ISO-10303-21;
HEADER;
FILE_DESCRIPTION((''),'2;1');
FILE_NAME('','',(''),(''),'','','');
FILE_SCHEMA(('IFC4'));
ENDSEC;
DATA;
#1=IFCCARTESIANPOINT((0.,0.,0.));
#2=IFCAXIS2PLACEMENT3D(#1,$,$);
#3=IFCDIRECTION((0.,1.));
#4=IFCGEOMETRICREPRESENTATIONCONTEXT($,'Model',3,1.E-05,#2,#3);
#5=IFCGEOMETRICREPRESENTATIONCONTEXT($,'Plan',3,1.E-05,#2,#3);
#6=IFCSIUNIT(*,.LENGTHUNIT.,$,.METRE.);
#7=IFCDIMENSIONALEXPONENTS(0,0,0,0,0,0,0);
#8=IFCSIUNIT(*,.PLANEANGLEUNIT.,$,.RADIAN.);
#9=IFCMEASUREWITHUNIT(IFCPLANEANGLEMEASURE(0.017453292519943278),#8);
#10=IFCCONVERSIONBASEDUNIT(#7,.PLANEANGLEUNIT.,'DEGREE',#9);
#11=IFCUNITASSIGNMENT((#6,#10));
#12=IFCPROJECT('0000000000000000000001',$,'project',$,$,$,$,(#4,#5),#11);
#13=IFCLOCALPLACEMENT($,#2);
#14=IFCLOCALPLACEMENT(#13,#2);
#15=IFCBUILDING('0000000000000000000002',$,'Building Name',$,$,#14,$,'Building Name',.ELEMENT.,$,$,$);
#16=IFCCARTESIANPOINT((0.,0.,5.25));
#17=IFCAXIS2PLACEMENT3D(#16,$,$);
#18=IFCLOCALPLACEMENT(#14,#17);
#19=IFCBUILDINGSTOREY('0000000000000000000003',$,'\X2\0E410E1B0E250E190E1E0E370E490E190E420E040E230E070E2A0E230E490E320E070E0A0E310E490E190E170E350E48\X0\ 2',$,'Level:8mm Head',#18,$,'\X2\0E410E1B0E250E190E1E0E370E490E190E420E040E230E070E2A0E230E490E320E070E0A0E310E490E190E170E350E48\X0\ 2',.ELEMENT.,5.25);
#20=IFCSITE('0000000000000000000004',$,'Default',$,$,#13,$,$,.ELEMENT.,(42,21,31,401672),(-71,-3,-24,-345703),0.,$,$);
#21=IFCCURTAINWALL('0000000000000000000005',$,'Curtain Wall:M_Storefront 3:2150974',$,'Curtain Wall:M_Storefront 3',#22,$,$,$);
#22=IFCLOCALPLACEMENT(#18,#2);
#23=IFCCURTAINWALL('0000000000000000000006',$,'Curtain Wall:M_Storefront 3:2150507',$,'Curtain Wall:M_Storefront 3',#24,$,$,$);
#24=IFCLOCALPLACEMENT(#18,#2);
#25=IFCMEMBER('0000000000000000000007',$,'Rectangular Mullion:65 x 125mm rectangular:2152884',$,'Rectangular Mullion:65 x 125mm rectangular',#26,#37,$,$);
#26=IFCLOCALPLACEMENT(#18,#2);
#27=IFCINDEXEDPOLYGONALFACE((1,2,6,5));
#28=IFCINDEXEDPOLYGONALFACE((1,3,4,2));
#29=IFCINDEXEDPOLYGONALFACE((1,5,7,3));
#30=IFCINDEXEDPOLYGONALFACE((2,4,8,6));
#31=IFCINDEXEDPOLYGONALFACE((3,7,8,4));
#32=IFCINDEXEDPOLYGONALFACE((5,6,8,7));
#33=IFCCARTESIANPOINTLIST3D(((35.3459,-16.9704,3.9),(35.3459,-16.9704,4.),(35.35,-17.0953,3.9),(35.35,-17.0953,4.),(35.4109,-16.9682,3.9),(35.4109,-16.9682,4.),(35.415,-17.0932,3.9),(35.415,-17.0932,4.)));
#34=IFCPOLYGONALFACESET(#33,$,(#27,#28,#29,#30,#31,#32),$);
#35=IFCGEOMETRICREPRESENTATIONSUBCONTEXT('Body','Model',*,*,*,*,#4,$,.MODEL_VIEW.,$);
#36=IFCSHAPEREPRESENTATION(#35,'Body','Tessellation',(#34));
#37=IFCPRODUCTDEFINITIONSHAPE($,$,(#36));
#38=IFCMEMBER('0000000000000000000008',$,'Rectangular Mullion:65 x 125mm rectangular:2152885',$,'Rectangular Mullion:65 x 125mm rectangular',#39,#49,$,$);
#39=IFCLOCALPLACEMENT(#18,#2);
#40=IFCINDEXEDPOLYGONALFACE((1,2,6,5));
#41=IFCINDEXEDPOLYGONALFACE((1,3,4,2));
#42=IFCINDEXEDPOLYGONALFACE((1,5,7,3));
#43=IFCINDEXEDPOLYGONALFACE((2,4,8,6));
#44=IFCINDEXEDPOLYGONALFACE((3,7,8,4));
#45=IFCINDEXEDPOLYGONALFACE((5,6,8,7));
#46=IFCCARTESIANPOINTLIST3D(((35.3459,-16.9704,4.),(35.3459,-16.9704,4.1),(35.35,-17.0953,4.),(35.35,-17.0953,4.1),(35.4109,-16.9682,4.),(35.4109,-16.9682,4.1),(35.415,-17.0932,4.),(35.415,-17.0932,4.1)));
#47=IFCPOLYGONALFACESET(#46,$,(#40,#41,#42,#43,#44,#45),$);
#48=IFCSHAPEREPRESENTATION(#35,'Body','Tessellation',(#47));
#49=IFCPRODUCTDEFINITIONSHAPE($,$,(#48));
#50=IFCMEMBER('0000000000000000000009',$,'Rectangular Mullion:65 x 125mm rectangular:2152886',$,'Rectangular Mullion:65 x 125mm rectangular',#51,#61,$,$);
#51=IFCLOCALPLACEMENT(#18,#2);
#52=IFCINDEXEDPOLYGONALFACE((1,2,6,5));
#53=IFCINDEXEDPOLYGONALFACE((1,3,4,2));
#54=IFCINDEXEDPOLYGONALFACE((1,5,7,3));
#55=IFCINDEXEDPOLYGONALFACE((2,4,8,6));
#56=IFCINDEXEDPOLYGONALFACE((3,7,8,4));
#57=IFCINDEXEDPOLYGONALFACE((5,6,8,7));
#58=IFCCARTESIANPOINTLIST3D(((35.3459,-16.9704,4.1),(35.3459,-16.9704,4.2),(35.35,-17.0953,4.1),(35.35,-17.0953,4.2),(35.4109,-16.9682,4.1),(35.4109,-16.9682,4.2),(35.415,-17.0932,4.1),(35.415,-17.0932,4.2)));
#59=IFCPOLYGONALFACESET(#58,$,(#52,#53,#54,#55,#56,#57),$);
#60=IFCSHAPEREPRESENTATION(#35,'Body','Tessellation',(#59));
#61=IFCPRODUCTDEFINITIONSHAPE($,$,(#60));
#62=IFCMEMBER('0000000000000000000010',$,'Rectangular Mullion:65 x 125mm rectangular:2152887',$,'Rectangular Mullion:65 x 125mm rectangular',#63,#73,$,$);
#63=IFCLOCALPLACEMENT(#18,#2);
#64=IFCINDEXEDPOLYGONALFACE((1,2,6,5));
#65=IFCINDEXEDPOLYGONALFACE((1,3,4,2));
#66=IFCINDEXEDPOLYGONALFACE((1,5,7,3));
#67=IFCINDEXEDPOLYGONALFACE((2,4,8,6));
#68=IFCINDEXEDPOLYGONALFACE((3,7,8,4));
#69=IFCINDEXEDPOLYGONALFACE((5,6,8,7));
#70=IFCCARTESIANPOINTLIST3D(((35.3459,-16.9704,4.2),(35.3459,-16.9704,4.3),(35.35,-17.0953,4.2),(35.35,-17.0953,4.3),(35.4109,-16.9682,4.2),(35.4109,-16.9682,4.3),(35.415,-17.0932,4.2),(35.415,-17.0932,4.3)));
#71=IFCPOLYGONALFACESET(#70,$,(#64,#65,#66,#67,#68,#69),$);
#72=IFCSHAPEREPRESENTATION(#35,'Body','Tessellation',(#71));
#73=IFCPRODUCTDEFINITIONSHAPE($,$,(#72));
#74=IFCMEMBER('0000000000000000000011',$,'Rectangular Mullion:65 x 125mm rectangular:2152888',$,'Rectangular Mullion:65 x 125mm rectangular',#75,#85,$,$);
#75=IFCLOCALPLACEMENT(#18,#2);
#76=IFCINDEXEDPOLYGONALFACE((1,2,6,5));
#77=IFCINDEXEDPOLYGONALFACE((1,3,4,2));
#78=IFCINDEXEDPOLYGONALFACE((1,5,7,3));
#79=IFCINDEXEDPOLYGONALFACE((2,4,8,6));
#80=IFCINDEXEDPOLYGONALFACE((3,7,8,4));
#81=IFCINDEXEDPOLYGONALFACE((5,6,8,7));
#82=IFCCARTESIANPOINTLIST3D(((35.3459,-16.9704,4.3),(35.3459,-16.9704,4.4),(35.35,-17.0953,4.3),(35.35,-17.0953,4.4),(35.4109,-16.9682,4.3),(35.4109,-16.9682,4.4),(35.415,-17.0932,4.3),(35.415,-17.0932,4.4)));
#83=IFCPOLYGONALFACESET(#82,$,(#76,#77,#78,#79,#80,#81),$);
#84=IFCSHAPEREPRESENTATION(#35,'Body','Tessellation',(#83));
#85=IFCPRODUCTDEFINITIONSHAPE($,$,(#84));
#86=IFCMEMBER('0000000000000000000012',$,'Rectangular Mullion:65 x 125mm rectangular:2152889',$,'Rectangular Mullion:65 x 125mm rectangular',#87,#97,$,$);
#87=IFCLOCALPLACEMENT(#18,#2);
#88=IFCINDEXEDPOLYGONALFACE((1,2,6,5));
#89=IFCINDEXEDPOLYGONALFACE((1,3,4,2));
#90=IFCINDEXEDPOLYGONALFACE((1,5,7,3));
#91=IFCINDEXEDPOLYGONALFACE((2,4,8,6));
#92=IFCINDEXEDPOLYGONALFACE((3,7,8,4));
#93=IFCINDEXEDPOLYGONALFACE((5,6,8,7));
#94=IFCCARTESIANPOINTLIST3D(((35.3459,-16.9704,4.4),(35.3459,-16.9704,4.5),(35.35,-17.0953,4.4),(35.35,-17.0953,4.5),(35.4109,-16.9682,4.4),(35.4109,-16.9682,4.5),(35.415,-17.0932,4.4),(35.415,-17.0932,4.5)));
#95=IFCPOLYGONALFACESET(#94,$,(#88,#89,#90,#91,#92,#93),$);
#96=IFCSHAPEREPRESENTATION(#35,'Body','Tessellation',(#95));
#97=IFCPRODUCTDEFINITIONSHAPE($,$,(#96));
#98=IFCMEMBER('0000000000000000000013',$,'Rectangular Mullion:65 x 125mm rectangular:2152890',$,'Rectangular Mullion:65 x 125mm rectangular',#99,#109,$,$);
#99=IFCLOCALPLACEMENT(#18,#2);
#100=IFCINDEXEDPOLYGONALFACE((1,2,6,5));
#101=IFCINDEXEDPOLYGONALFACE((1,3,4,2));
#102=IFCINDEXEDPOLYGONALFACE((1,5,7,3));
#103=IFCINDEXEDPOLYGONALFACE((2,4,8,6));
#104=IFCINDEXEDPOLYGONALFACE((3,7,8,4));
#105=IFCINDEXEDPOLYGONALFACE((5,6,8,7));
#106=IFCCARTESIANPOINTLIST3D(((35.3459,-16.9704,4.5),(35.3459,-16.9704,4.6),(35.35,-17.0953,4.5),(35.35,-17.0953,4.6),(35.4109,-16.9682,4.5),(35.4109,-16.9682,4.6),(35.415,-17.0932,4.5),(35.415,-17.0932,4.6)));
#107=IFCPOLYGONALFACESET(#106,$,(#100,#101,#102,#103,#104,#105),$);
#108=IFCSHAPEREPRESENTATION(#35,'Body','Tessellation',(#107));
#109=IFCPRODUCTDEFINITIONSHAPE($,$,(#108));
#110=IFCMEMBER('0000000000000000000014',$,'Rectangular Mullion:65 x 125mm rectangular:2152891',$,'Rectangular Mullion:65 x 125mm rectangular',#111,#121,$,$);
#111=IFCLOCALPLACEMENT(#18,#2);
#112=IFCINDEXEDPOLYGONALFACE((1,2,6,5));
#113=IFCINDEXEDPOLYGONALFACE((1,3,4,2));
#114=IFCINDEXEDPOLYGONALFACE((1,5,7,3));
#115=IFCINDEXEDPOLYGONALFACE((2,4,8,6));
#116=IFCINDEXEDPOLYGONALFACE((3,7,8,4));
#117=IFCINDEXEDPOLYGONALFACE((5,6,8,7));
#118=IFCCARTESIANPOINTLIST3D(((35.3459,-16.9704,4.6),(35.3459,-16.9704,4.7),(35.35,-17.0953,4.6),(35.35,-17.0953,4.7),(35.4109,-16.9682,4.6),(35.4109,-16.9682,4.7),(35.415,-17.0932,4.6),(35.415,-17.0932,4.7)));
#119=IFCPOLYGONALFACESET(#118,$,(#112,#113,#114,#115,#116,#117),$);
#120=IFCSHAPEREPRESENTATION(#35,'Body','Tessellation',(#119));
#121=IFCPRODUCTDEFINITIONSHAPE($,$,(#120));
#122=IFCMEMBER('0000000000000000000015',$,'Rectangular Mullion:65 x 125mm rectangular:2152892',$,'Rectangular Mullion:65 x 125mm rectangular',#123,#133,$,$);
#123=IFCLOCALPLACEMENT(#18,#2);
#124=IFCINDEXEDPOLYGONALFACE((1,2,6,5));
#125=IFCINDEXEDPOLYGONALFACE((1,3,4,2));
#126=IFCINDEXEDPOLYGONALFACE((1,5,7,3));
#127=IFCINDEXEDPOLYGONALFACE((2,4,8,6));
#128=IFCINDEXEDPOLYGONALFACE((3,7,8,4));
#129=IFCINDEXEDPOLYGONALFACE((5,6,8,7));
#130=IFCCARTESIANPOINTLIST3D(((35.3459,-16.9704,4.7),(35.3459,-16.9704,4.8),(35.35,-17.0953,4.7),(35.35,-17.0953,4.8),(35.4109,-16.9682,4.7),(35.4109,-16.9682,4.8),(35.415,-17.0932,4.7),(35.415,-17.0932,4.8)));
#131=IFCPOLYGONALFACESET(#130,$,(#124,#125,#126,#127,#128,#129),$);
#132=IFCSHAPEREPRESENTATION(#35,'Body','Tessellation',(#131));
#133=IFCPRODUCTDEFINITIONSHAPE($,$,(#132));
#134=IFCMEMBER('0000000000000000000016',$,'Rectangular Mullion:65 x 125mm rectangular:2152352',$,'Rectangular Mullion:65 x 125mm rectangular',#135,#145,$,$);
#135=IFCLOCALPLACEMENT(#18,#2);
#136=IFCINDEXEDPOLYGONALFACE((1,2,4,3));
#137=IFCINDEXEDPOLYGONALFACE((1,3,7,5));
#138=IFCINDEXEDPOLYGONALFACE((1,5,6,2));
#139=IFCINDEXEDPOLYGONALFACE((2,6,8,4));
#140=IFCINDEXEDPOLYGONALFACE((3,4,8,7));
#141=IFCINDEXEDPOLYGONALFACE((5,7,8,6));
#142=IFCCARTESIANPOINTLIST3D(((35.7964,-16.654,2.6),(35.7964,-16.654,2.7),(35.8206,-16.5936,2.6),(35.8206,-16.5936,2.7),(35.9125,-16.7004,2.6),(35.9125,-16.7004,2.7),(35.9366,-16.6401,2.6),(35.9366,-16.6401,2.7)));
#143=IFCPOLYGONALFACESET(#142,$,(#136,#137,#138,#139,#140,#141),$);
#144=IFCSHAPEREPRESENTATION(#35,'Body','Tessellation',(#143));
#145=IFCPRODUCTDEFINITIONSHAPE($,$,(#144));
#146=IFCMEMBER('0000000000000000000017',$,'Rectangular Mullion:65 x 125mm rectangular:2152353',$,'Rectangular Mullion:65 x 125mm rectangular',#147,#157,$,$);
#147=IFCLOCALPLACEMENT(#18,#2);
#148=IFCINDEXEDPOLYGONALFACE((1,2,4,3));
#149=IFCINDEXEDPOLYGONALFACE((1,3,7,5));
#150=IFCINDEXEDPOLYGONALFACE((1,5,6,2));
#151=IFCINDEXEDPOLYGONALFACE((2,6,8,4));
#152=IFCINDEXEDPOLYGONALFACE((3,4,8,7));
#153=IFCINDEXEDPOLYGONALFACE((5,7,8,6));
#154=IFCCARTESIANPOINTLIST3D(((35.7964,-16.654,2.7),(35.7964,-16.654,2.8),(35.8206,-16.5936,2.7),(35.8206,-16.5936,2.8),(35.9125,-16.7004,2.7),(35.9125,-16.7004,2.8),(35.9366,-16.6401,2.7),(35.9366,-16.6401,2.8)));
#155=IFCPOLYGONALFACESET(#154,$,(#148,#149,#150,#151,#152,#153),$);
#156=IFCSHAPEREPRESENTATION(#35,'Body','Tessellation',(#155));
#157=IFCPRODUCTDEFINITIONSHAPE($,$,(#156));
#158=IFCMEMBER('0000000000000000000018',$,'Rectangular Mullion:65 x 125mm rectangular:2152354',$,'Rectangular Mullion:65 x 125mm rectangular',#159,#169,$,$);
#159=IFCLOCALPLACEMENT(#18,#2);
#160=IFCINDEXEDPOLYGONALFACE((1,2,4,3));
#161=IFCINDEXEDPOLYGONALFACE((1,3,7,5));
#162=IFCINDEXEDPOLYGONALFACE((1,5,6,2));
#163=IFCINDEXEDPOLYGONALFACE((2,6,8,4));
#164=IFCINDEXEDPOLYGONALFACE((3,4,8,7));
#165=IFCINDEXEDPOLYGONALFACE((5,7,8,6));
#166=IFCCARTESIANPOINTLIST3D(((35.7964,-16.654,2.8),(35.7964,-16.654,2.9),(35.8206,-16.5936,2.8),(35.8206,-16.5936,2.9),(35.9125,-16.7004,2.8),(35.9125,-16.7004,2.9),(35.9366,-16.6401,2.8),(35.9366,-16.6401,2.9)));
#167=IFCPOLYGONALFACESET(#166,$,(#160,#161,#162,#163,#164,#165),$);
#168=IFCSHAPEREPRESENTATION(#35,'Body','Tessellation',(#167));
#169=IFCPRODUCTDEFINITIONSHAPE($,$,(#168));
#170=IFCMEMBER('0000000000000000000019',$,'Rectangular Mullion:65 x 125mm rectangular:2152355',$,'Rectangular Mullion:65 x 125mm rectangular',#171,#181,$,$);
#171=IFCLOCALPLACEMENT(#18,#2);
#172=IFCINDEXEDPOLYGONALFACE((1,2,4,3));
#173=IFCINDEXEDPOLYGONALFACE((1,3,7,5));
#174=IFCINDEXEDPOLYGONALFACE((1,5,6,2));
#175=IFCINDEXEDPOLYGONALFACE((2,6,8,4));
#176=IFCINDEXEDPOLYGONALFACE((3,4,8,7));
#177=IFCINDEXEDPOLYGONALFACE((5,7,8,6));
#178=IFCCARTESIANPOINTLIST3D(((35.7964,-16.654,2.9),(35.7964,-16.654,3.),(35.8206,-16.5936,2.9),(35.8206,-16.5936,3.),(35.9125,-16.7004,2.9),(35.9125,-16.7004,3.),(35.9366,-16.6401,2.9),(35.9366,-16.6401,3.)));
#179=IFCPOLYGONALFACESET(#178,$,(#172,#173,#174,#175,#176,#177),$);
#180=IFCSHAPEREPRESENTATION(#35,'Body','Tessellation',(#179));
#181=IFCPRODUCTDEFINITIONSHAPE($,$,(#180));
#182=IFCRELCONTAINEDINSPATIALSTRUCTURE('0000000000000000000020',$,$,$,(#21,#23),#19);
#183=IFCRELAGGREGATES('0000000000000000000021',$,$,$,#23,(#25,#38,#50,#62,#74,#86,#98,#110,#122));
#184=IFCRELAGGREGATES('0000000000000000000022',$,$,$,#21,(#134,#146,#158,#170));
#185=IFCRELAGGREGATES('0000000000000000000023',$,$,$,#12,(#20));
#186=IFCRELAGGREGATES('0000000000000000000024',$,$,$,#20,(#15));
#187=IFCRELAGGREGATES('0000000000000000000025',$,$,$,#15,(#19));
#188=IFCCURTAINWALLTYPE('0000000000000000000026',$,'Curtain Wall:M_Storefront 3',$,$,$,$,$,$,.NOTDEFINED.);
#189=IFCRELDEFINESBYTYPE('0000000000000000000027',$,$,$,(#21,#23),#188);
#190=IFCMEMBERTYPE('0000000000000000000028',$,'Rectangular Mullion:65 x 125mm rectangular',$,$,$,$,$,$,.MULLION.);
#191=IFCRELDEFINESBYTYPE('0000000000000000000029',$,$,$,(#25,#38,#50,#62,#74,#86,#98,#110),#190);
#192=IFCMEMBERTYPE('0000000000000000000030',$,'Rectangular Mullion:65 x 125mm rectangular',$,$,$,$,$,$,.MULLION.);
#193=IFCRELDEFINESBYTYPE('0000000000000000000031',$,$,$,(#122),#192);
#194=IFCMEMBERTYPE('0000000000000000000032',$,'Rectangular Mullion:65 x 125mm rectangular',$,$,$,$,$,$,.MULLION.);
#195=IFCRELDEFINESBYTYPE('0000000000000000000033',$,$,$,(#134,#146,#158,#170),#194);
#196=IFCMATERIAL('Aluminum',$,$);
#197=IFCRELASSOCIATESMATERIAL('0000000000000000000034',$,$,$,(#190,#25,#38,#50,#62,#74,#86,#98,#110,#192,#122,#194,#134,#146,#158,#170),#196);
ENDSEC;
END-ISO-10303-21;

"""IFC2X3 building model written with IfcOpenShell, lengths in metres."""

from ifc_helpers import new_model, entity, si_unit, converted_unit, direction, frame, origin, origin_2d_with_axis, place, context, subcontext, project, spatial, rectangle, extrude, source, transform, mapped, material, type_object, type_shapes, element, aggregate, save


model = new_model("IFC2X3")

# Units and contexts
model_context = context("Model", 3, precision=1e-05, world=origin(), true_north=direction((0.0, 1.0)))
plan_context = context("Plan", 3, precision=1e-05, world=origin(), true_north=direction((0.0, 1.0)))
body_context = subcontext(model_context, "Body", "Model", "MODEL_VIEW")
ifc_project = project(units=[si_unit("LENGTHUNIT", "METRE"), converted_unit("PLANEANGLEUNIT", "DEGREE", entity("IfcPlaneAngleMeasure", 0.017453292519943278), si_unit("PLANEANGLEUNIT", "RADIAN"), dimensions=[0, 0, 0, 0, 0, 0, 0])], contexts=[model_context, plan_context])

# Site, building, storey
site_placement = place(None, origin())
site = spatial("IfcSite", under=ifc_project, at=site_placement, Name="Default", CompositionType="ELEMENT", RefLatitude=(42, 21, 31, 401672), RefLongitude=(-71, -3, -24, -345703), RefElevation=0.0)
building_placement = place(site_placement, origin())
building = spatial("IfcBuilding", under=site, at=building_placement, Name="Building Name", LongName="Building Name", CompositionType="ELEMENT")
storey_placement = place(building_placement, frame((0.0, 0.0, 5.25)))
storey = spatial("IfcBuildingStorey", under=building, at=storey_placement, Name="แปลนพื้นโครงสร้างชั้นที่ 2", ObjectType="Level:8mm Head", LongName="แปลนพื้นโครงสร้างชั้นที่ 2", CompositionType="ELEMENT", Elevation=5.25)

# Curtain wall
curtain_wall_type = type_object("IfcCurtainWallType", Name="Curtain Wall:M_Storefront 3", PredefinedType="NOTDEFINED")
curtain_wall_1_placement = place(storey_placement, frame((0.0, 0.0, -5.25)))
curtain_wall_1 = element("IfcCurtainWall", 1, at=curtain_wall_1_placement, inside=storey, type_object=curtain_wall_type, Name="Curtain Wall:M_Storefront 3:2150974", ObjectType="Curtain Wall:M_Storefront 3")
ifc_material = material(Name="Aluminum")

# Curtain wall, members
curtain_wall_2_placement = place(storey_placement, frame((0.0, 0.0, -5.25)))
curtain_wall_2 = element("IfcCurtainWall", 2, at=curtain_wall_2_placement, inside=storey, type_object=curtain_wall_type, Name="Curtain Wall:M_Storefront 3:2150507", ObjectType="Curtain Wall:M_Storefront 3")
member_type_1 = type_object("IfcMemberType", Name="Rectangular Mullion:65 x 125mm rectangular", PredefinedType="MULLION", material=ifc_material)
shared_shape_1 = source(origin(), body_context, "Body", "SweptSolid", [
    extrude(rectangle(XDim=0.065, YDim=0.125, at=origin_2d_with_axis()), frame((-0.0325, 0.0, -0.1), z_axis=(0.0, 0.0, 1.0), x_axis=(-1.0, 0.0, 0.0)), (0.0, 0.0, 1.0), 0.1),
])
type_shapes(member_type_1, [shared_shape_1])
member_1_placement = place(curtain_wall_2_placement, frame((35.4129, -17.0307, 9.15), z_axis=(0.0, 0.0, -1.0), x_axis=(0.99946, 0.032862, 0.0)))
member_1 = element("IfcMember", 3, at=member_1_placement, type_object=member_type_1, material=ifc_material, Name="Rectangular Mullion:65 x 125mm rectangular:2152884", ObjectType="Rectangular Mullion:65 x 125mm rectangular", context=body_context, shape_type="MappedRepresentation", body=[
    mapped(shared_shape_1, transform((0.0, 0.0, 0.0), scale=1.0)),
])
member_2_placement = place(curtain_wall_2_placement, frame((35.4129, -17.0307, 9.25), z_axis=(0.0, 0.0, -1.0), x_axis=(0.99946, 0.032862, 0.0)))
member_2 = element("IfcMember", 4, at=member_2_placement, type_object=member_type_1, material=ifc_material, Name="Rectangular Mullion:65 x 125mm rectangular:2152885", ObjectType="Rectangular Mullion:65 x 125mm rectangular", context=body_context, shape_type="MappedRepresentation", body=[
    mapped(shared_shape_1, transform((0.0, 0.0, 0.0), scale=1.0)),
])
member_3_placement = place(curtain_wall_2_placement, frame((35.4129, -17.0307, 9.35), z_axis=(0.0, 0.0, -1.0), x_axis=(0.99946, 0.032862, 0.0)))
member_3 = element("IfcMember", 5, at=member_3_placement, type_object=member_type_1, material=ifc_material, Name="Rectangular Mullion:65 x 125mm rectangular:2152886", ObjectType="Rectangular Mullion:65 x 125mm rectangular", context=body_context, shape_type="MappedRepresentation", body=[
    mapped(shared_shape_1, transform((0.0, 0.0, 0.0), scale=1.0)),
])
member_4_placement = place(curtain_wall_2_placement, frame((35.4129, -17.0307, 9.45), z_axis=(0.0, 0.0, -1.0), x_axis=(0.99946, 0.032862, 0.0)))
member_4 = element("IfcMember", 6, at=member_4_placement, type_object=member_type_1, material=ifc_material, Name="Rectangular Mullion:65 x 125mm rectangular:2152887", ObjectType="Rectangular Mullion:65 x 125mm rectangular", context=body_context, shape_type="MappedRepresentation", body=[
    mapped(shared_shape_1, transform((0.0, 0.0, 0.0), scale=1.0)),
])
member_5_placement = place(curtain_wall_2_placement, frame((35.4129, -17.0307, 9.55), z_axis=(0.0, 0.0, -1.0), x_axis=(0.99946, 0.032862, 0.0)))
member_5 = element("IfcMember", 7, at=member_5_placement, type_object=member_type_1, material=ifc_material, Name="Rectangular Mullion:65 x 125mm rectangular:2152888", ObjectType="Rectangular Mullion:65 x 125mm rectangular", context=body_context, shape_type="MappedRepresentation", body=[
    mapped(shared_shape_1, transform((0.0, 0.0, 0.0), scale=1.0)),
])
member_6_placement = place(curtain_wall_2_placement, frame((35.4129, -17.0307, 9.65), z_axis=(0.0, 0.0, -1.0), x_axis=(0.99946, 0.032862, 0.0)))
member_6 = element("IfcMember", 8, at=member_6_placement, type_object=member_type_1, material=ifc_material, Name="Rectangular Mullion:65 x 125mm rectangular:2152889", ObjectType="Rectangular Mullion:65 x 125mm rectangular", context=body_context, shape_type="MappedRepresentation", body=[
    mapped(shared_shape_1, transform((0.0, 0.0, 0.0), scale=1.0)),
])
member_7_placement = place(curtain_wall_2_placement, frame((35.4129, -17.0307, 9.75), z_axis=(0.0, 0.0, -1.0), x_axis=(0.99946, 0.032862, 0.0)))
member_7 = element("IfcMember", 9, at=member_7_placement, type_object=member_type_1, material=ifc_material, Name="Rectangular Mullion:65 x 125mm rectangular:2152890", ObjectType="Rectangular Mullion:65 x 125mm rectangular", context=body_context, shape_type="MappedRepresentation", body=[
    mapped(shared_shape_1, transform((0.0, 0.0, 0.0), scale=1.0)),
])
member_8_placement = place(curtain_wall_2_placement, frame((35.4129, -17.0307, 9.85), z_axis=(0.0, 0.0, -1.0), x_axis=(0.99946, 0.032862, 0.0)))
member_8 = element("IfcMember", 10, at=member_8_placement, type_object=member_type_1, material=ifc_material, Name="Rectangular Mullion:65 x 125mm rectangular:2152891", ObjectType="Rectangular Mullion:65 x 125mm rectangular", context=body_context, shape_type="MappedRepresentation", body=[
    mapped(shared_shape_1, transform((0.0, 0.0, 0.0), scale=1.0)),
])
member_type_2 = type_object("IfcMemberType", Name="Rectangular Mullion:65 x 125mm rectangular", PredefinedType="MULLION", material=ifc_material)
shared_shape_2 = source(origin(), body_context, "Body", "SweptSolid", [
    extrude(rectangle(XDim=0.065, YDim=0.125, at=origin_2d_with_axis()), frame((-0.0325, 0.0, -0.1), z_axis=(0.0, 0.0, 1.0), x_axis=(-1.0, 0.0, 0.0)), (0.0, 0.0, 1.0), 0.1),
])
type_shapes(member_type_2, [shared_shape_2])
member_9_placement = place(curtain_wall_2_placement, frame((35.4129, -17.0307, 9.95), z_axis=(0.0, 0.0, -1.0), x_axis=(0.99946, 0.032862, 0.0)))
member_9 = element("IfcMember", 11, at=member_9_placement, type_object=member_type_2, material=ifc_material, Name="Rectangular Mullion:65 x 125mm rectangular:2152892", ObjectType="Rectangular Mullion:65 x 125mm rectangular", context=body_context, shape_type="MappedRepresentation", body=[
    mapped(shared_shape_2, transform((0.0, 0.0, 0.0), scale=1.0)),
])
aggregate(curtain_wall_2, [member_1, member_2, member_3, member_4, member_5, member_6, member_7, member_8, member_9])

# Members
member_type_3 = type_object("IfcMemberType", Name="Rectangular Mullion:65 x 125mm rectangular", PredefinedType="MULLION", material=ifc_material)
shared_shape_3 = source(origin(), body_context, "Body", "SweptSolid", [
    extrude(rectangle(XDim=0.065, YDim=0.125, at=origin_2d_with_axis()), frame((-0.0325, 0.0, -0.1), z_axis=(0.0, 0.0, 1.0), x_axis=(-1.0, 0.0, 0.0)), (0.0, 0.0, 1.0), 0.1),
])
type_shapes(member_type_3, [shared_shape_3])
member_10_placement = place(curtain_wall_1_placement, frame((35.8545, -16.6772, 7.95), z_axis=(0.0, 0.0, 1.0), x_axis=(-0.371573, -0.928404, 0.0)))
member_10 = element("IfcMember", 12, at=member_10_placement, type_object=member_type_3, material=ifc_material, Name="Rectangular Mullion:65 x 125mm rectangular:2152352", ObjectType="Rectangular Mullion:65 x 125mm rectangular", context=body_context, shape_type="MappedRepresentation", body=[
    mapped(shared_shape_3, transform((0.0, 0.0, 0.0), scale=1.0)),
])
member_11_placement = place(curtain_wall_1_placement, frame((35.8545, -16.6772, 8.05), z_axis=(0.0, 0.0, 1.0), x_axis=(-0.371573, -0.928404, 0.0)))
member_11 = element("IfcMember", 13, at=member_11_placement, type_object=member_type_3, material=ifc_material, Name="Rectangular Mullion:65 x 125mm rectangular:2152353", ObjectType="Rectangular Mullion:65 x 125mm rectangular", context=body_context, shape_type="MappedRepresentation", body=[
    mapped(shared_shape_3, transform((0.0, 0.0, 0.0), scale=1.0)),
])
member_12_placement = place(curtain_wall_1_placement, frame((35.8545, -16.6772, 8.15), z_axis=(0.0, 0.0, 1.0), x_axis=(-0.371573, -0.928404, 0.0)))
member_12 = element("IfcMember", 14, at=member_12_placement, type_object=member_type_3, material=ifc_material, Name="Rectangular Mullion:65 x 125mm rectangular:2152354", ObjectType="Rectangular Mullion:65 x 125mm rectangular", context=body_context, shape_type="MappedRepresentation", body=[
    mapped(shared_shape_3, transform((0.0, 0.0, 0.0), scale=1.0)),
])
member_13_placement = place(curtain_wall_1_placement, frame((35.8545, -16.6772, 8.25), z_axis=(0.0, 0.0, 1.0), x_axis=(-0.371573, -0.928404, 0.0)))
member_13 = element("IfcMember", 15, at=member_13_placement, type_object=member_type_3, material=ifc_material, Name="Rectangular Mullion:65 x 125mm rectangular:2152355", ObjectType="Rectangular Mullion:65 x 125mm rectangular", context=body_context, shape_type="MappedRepresentation", body=[
    mapped(shared_shape_3, transform((0.0, 0.0, 0.0), scale=1.0)),
])
aggregate(curtain_wall_1, [member_10, member_11, member_12, member_13])

save(model, "model.ifc")
